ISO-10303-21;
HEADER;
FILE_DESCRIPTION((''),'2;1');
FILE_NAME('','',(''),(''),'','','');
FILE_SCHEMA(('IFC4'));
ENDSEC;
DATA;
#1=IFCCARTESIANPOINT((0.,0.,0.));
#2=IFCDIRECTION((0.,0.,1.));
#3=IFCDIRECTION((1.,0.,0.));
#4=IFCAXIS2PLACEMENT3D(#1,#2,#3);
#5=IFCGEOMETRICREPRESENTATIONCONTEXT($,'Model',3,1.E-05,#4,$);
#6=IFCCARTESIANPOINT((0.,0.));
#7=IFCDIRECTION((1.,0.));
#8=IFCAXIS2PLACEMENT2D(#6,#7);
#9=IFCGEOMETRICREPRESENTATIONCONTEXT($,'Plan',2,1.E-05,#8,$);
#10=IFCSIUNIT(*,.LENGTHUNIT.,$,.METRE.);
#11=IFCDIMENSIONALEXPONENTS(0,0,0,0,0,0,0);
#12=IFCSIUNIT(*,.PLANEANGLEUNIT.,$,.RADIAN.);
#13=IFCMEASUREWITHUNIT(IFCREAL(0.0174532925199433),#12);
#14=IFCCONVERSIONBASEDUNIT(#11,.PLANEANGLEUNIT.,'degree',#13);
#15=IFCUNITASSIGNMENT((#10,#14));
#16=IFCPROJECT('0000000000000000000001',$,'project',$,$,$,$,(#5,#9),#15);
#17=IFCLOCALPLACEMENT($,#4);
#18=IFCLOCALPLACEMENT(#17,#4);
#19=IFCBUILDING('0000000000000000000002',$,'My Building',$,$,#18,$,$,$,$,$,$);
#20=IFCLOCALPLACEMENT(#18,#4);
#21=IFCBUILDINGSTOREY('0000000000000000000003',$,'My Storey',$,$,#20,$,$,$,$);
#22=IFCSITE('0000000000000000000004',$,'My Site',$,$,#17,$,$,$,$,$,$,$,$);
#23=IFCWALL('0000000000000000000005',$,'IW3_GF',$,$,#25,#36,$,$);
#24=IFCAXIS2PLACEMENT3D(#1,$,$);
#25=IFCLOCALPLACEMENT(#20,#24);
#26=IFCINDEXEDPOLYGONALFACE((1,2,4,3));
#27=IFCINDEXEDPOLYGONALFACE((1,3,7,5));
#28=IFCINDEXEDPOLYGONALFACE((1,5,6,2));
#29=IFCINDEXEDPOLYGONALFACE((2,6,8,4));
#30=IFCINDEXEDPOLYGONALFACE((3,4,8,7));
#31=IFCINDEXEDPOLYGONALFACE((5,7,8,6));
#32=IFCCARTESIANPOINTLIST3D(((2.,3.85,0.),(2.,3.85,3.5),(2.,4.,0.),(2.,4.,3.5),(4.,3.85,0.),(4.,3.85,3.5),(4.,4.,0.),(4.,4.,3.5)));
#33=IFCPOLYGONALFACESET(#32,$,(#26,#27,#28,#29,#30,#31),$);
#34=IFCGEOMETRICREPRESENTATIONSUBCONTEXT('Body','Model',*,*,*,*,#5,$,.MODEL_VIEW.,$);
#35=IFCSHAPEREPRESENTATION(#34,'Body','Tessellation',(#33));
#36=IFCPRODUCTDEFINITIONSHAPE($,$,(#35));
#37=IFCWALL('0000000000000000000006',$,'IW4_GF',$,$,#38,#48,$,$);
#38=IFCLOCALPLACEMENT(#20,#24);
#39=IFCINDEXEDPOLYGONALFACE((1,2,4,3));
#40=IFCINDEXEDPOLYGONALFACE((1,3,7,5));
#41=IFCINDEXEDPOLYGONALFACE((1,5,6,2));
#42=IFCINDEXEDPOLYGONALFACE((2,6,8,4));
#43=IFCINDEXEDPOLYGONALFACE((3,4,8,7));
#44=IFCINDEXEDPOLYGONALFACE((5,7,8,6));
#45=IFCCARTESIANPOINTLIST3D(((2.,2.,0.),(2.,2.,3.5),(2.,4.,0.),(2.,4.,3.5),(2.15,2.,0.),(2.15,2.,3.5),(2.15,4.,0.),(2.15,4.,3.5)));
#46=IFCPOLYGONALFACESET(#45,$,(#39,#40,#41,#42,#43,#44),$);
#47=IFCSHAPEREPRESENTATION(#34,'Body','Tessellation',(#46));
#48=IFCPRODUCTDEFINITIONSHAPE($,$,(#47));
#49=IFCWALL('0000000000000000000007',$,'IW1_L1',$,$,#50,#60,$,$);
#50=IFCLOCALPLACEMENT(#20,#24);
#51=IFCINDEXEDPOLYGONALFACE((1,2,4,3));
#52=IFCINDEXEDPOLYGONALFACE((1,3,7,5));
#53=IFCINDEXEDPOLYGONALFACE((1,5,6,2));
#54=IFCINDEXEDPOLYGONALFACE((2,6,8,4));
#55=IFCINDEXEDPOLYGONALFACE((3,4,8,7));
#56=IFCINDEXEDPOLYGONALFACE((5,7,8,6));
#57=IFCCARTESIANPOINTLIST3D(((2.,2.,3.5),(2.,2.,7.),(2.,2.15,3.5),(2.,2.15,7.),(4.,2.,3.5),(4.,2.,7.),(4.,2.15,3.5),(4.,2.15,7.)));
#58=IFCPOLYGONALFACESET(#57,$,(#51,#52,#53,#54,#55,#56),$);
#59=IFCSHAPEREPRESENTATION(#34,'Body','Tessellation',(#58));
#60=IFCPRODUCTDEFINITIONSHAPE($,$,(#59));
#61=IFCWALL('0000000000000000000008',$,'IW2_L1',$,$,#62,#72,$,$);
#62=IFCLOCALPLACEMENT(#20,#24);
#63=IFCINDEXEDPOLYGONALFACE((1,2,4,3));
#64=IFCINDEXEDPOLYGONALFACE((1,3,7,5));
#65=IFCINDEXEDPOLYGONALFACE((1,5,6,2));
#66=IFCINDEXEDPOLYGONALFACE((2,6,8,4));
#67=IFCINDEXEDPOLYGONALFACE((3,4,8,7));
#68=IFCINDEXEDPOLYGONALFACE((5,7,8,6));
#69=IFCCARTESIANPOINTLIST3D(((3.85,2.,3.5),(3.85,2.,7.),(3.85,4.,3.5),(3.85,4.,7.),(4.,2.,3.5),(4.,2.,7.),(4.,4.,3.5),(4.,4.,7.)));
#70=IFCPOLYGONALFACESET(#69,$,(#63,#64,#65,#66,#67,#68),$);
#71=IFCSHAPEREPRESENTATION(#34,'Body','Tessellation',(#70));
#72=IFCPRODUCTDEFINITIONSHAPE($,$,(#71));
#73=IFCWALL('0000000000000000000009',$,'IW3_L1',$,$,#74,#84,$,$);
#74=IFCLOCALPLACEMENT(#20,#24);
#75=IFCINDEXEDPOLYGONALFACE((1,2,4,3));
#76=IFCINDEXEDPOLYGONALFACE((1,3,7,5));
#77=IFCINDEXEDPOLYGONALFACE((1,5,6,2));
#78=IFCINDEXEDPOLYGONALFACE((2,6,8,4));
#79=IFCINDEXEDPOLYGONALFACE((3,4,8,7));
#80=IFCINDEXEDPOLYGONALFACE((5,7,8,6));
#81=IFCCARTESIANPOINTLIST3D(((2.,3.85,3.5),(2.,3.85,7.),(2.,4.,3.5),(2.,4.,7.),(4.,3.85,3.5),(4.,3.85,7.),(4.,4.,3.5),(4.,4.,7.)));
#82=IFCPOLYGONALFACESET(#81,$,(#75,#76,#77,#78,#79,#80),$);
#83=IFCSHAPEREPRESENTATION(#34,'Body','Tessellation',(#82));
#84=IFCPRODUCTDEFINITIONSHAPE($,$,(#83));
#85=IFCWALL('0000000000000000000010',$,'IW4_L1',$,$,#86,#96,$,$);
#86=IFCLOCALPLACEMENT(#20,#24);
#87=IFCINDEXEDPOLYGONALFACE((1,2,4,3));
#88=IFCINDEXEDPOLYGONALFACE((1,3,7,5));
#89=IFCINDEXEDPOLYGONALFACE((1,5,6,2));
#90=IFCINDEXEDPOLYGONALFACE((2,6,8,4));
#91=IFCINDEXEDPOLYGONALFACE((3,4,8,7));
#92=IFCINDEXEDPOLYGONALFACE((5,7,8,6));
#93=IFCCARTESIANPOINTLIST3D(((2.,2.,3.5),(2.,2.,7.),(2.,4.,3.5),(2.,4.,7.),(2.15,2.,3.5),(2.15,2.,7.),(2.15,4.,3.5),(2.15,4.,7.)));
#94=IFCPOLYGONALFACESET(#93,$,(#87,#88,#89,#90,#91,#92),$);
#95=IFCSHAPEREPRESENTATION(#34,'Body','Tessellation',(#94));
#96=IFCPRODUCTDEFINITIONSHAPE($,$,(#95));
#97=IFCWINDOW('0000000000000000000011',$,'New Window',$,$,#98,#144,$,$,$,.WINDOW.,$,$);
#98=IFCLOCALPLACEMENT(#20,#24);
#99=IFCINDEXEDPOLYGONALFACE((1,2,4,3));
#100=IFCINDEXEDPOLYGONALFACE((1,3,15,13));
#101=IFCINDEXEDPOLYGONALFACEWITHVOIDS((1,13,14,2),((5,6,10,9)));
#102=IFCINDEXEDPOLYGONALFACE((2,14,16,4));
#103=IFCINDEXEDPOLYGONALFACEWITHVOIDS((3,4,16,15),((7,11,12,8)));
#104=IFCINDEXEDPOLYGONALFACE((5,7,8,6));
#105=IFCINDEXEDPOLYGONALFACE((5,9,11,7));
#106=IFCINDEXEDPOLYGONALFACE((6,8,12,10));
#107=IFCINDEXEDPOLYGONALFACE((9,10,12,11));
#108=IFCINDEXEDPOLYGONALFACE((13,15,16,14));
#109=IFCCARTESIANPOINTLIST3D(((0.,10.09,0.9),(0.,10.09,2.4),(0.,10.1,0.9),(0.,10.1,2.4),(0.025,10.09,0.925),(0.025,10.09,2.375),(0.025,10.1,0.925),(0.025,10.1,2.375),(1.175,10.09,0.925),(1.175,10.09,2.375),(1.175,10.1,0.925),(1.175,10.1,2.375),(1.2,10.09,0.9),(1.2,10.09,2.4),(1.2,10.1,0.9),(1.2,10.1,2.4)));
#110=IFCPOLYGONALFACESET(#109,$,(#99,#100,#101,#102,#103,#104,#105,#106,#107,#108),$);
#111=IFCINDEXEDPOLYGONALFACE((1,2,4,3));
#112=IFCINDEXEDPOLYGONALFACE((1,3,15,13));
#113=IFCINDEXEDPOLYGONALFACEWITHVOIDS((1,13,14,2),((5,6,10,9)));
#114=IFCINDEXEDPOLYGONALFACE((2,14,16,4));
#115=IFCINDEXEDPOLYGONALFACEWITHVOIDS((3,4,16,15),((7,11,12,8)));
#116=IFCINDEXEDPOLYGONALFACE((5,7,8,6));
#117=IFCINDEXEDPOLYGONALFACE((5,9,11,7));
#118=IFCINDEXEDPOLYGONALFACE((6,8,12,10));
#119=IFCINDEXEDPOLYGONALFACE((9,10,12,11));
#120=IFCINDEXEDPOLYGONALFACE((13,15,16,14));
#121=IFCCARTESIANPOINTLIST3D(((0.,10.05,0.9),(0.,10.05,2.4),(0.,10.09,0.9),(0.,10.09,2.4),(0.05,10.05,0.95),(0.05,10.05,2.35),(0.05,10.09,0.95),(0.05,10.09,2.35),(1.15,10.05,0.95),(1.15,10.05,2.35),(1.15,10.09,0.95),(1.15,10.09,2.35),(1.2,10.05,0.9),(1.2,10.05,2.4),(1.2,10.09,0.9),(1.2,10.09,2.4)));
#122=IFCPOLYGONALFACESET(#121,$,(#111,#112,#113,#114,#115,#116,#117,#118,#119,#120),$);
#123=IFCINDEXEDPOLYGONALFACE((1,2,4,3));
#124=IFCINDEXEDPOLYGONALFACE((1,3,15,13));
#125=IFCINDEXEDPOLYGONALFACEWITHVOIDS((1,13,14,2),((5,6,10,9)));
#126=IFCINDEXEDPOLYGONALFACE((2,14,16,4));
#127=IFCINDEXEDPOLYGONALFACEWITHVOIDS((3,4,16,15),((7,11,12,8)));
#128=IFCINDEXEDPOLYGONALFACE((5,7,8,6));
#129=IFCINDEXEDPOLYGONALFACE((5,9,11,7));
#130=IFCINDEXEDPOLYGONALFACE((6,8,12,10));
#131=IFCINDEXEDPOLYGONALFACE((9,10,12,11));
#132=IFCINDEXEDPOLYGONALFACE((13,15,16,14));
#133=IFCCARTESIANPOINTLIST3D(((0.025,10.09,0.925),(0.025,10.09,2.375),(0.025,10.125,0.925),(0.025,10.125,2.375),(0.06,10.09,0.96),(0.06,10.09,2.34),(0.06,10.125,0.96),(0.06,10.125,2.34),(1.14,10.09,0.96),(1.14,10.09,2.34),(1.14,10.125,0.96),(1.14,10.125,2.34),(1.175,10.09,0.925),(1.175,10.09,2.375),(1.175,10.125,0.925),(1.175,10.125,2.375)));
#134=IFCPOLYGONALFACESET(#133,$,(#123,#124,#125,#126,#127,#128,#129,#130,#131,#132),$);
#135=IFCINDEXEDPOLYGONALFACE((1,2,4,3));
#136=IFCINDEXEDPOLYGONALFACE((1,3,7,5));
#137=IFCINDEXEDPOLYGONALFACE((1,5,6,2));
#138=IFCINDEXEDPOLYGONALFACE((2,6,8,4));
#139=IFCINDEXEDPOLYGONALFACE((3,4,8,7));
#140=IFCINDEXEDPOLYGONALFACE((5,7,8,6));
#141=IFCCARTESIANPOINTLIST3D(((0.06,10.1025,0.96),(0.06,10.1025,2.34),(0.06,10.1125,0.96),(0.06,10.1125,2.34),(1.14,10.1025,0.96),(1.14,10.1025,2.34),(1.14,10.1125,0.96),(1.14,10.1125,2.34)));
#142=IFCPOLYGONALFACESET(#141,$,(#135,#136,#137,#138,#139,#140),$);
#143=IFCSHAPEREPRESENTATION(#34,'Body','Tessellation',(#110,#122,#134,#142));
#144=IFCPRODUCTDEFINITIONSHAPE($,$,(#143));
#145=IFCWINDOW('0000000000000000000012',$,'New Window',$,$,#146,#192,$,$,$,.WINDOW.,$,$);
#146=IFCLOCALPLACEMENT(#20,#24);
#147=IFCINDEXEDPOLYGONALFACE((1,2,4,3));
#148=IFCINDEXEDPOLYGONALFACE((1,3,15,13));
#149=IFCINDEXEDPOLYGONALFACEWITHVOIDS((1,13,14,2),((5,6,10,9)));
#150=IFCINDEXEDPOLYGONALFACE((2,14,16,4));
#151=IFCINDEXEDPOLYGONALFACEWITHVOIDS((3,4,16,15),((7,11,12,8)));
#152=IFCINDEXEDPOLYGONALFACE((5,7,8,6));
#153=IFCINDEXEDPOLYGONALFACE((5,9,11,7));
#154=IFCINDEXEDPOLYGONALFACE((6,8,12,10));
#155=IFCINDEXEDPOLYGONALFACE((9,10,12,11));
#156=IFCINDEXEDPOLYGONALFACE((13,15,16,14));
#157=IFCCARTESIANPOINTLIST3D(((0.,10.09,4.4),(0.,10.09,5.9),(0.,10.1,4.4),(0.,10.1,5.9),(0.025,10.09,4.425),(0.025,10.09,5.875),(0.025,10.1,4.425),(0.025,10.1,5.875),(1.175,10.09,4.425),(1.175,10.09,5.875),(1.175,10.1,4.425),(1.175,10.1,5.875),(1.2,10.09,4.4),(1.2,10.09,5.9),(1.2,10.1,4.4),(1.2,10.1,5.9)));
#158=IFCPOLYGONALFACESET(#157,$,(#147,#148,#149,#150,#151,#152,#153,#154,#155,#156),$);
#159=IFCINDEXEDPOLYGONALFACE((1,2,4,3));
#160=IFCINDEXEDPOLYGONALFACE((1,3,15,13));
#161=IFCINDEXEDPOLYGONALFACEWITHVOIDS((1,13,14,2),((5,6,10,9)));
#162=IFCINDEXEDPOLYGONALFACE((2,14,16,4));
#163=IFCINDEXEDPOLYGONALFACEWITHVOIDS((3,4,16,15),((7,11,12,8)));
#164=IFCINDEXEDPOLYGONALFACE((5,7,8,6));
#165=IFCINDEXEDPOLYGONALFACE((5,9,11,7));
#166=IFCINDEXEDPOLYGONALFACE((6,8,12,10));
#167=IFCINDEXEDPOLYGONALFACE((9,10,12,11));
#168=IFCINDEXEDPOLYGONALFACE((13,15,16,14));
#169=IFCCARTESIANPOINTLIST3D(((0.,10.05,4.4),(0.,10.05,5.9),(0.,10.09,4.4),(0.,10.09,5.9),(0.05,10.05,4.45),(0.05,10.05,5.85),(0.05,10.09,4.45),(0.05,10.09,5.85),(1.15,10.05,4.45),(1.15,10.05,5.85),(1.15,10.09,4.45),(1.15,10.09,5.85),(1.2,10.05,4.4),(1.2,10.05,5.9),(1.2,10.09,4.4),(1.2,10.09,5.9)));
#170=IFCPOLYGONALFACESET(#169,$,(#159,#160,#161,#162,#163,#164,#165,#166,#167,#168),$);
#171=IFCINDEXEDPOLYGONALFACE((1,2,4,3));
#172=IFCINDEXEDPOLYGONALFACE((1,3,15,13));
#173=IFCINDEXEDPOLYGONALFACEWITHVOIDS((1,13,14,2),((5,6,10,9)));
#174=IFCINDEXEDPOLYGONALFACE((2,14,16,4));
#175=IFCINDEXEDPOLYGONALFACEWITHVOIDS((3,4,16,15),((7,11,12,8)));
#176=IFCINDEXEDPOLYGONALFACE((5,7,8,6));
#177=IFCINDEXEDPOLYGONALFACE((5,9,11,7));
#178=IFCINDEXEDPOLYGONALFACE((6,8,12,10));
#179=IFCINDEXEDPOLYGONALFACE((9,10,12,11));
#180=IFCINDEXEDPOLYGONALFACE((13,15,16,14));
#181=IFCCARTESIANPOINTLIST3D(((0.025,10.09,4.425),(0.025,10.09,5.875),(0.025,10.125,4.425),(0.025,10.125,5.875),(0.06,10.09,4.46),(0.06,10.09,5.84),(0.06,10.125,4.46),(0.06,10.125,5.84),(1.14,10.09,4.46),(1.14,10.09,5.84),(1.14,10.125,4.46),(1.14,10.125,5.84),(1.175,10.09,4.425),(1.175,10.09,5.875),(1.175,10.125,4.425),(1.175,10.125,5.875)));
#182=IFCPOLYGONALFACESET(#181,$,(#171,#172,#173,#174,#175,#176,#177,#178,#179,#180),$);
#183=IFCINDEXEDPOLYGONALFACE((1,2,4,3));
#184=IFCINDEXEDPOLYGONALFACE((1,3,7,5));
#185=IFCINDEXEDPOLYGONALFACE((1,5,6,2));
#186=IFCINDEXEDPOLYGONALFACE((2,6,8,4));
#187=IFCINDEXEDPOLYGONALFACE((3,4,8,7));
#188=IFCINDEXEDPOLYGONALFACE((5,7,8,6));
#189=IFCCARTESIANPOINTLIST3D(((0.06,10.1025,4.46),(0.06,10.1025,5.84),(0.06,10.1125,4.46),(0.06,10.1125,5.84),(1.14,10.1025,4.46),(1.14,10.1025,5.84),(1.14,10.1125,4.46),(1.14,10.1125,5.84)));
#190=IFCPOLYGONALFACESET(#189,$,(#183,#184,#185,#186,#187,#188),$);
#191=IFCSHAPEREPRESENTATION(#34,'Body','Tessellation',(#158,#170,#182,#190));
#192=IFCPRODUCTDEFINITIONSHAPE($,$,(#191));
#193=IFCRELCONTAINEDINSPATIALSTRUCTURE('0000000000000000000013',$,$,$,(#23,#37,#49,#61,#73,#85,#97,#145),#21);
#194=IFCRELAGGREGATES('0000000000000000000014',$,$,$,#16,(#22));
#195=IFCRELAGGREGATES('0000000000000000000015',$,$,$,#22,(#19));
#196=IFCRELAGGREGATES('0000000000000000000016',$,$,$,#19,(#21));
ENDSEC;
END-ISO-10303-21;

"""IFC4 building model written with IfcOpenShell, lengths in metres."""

from ifc_helpers import new_model, entity, si_unit, converted_unit, frame, origin_with_axes, origin_2d_with_axis, place, context, subcontext, project, spatial, line, indexed_curve, outline, extrude, element, save


model = new_model("IFC4")

# Units and contexts
model_context = context("Model", 3, precision=1e-05, world=origin_with_axes())
plan_context = context("Plan", 2, precision=1e-05, world=origin_2d_with_axis())
body_context = subcontext(model_context, "Body", "Model", "MODEL_VIEW")
ifc_project = project(units=[si_unit("LENGTHUNIT", "METRE"), converted_unit("PLANEANGLEUNIT", "degree", entity("IfcReal", 0.0174532925199433), si_unit("PLANEANGLEUNIT", "RADIAN"), dimensions=[0, 0, 0, 0, 0, 0, 0])], contexts=[model_context, plan_context])

# Site, building, storey
site_placement = place(None, origin_with_axes())
site = spatial("IfcSite", under=ifc_project, at=site_placement, Name="My Site")
building_placement = place(site_placement, origin_with_axes())
building = spatial("IfcBuilding", under=site, at=building_placement, Name="My Building")
storey_placement = place(building_placement, origin_with_axes())
storey = spatial("IfcBuildingStorey", under=building, at=storey_placement, Name="My Storey")

# Walls
for number, where, z_axis, x_axis, name in (
    (1, (4.0, 4.0, 0.0), (0.0, 0.0, 1.0), (-1.0, 0.0, 0.0), "IW3_GF"),
    (2, (2.0, 4.0, 0.0), (0.0, 0.0, 1.0), (0.0, -1.0, 0.0), "IW4_GF"),
):
    element("IfcWall", number, at=place(storey_placement, frame(where, z_axis=z_axis, x_axis=x_axis)), inside=storey, Name=name, context=body_context, shape_type="SweptSolid", body=[
        extrude(outline(indexed_curve([(0.0, 0.0), (0.0, 0.15), (2.0, 0.15), (2.0, 0.0), (0.0, 0.0)], self_intersect=False)), origin_with_axes(), (0.0, 0.0, 1.0), 3.5),
    ])
for number, where, z_axis, x_axis, name in (
    (3, (2.0, 2.0, 3.5), (0.0, 0.0, 1.0), (1.0, 0.0, 0.0), "IW1_L1"),
    (4, (4.0, 2.0, 3.5), (0.0, 0.0, 1.0), (0.0, 1.0, 0.0), "IW2_L1"),
    (5, (4.0, 4.0, 3.5), (0.0, 0.0, 1.0), (-1.0, 0.0, 0.0), "IW3_L1"),
    (6, (2.0, 4.0, 3.5), (0.0, 0.0, 1.0), (0.0, -1.0, 0.0), "IW4_L1"),
):
    element("IfcWall", number, at=place(storey_placement, frame(where, z_axis=z_axis, x_axis=x_axis)), inside=storey, Name=name, context=body_context, shape_type="SweptSolid", body=[
        extrude(outline(indexed_curve([(0.0, 0.0), (0.0, 0.15), (2.0, 0.15), (2.0, 0.0), (0.0, 0.0)], self_intersect=False)), origin_with_axes(), (0.0, 0.0, 1.0), 3.5),
    ])

# Windows
for number, where, z_axis, x_axis, name in (
    (7, (0.0, 10.0, 0.9), (0.0, 0.0, 1.0), (1.0, 0.0, 0.0), "New Window"),
    (8, (0.0, 10.0, 4.4), (0.0, 0.0, 1.0), (1.0, 0.0, 0.0), "New Window"),
):
    element("IfcWindow", number, at=place(storey_placement, frame(where, z_axis=z_axis, x_axis=x_axis)), inside=storey, Name=name, PredefinedType="WINDOW", context=body_context, shape_type="SweptSolid", body=[
        extrude(outline(indexed_curve([(0.0, 0.0), (1.2, 0.0), (1.2, 1.5), (0.0, 1.5)], segments=[line(1, 2, 3, 4, 1)]), holes=[indexed_curve([(0.025, 0.025), (1.175, 0.025), (1.175, 1.475), (0.025, 1.475)], segments=[line(1, 2, 3, 4, 1)])]), frame((0.0, 0.09, 0.0), z_axis=(0.0, -1.0, 0.0), x_axis=(1.0, 0.0, 0.0)), (0.0, 0.0, -1.0), 0.01),
        extrude(outline(indexed_curve([(0.0, 0.0), (1.2, 0.0), (1.2, 1.5), (0.0, 1.5)], segments=[line(1, 2, 3, 4, 1)]), holes=[indexed_curve([(0.05, 0.05), (1.15, 0.05), (1.15, 1.45), (0.05, 1.45)], segments=[line(1, 2, 3, 4, 1)])]), frame((0.0, 0.05, 0.0), z_axis=(0.0, -1.0, 0.0), x_axis=(1.0, 0.0, 0.0)), (0.0, 0.0, -1.0), 0.04),
        extrude(outline(indexed_curve([(0.0, 0.0), (1.15, 0.0), (1.15, 1.45), (0.0, 1.45)], segments=[line(1, 2, 3, 4, 1)]), holes=[indexed_curve([(0.035, 0.035), (1.115, 0.035), (1.115, 1.415), (0.035, 1.415)], segments=[line(1, 2, 3, 4, 1)])]), frame((0.025, 0.09, 0.025), z_axis=(0.0, -1.0, 0.0), x_axis=(1.0, 0.0, 0.0)), (0.0, 0.0, -1.0), 0.035),
        extrude(outline(indexed_curve([(0.035, 0.035), (1.115, 0.035), (1.115, 1.415), (0.035, 1.415)], segments=[line(1, 2, 3, 4, 1)])), frame((0.025, 0.1025, 0.025), z_axis=(0.0, -1.0, 0.0), x_axis=(1.0, 0.0, 0.0)), (0.0, 0.0, -1.0), 0.01),
    ])

save(model, "model.ifc")
